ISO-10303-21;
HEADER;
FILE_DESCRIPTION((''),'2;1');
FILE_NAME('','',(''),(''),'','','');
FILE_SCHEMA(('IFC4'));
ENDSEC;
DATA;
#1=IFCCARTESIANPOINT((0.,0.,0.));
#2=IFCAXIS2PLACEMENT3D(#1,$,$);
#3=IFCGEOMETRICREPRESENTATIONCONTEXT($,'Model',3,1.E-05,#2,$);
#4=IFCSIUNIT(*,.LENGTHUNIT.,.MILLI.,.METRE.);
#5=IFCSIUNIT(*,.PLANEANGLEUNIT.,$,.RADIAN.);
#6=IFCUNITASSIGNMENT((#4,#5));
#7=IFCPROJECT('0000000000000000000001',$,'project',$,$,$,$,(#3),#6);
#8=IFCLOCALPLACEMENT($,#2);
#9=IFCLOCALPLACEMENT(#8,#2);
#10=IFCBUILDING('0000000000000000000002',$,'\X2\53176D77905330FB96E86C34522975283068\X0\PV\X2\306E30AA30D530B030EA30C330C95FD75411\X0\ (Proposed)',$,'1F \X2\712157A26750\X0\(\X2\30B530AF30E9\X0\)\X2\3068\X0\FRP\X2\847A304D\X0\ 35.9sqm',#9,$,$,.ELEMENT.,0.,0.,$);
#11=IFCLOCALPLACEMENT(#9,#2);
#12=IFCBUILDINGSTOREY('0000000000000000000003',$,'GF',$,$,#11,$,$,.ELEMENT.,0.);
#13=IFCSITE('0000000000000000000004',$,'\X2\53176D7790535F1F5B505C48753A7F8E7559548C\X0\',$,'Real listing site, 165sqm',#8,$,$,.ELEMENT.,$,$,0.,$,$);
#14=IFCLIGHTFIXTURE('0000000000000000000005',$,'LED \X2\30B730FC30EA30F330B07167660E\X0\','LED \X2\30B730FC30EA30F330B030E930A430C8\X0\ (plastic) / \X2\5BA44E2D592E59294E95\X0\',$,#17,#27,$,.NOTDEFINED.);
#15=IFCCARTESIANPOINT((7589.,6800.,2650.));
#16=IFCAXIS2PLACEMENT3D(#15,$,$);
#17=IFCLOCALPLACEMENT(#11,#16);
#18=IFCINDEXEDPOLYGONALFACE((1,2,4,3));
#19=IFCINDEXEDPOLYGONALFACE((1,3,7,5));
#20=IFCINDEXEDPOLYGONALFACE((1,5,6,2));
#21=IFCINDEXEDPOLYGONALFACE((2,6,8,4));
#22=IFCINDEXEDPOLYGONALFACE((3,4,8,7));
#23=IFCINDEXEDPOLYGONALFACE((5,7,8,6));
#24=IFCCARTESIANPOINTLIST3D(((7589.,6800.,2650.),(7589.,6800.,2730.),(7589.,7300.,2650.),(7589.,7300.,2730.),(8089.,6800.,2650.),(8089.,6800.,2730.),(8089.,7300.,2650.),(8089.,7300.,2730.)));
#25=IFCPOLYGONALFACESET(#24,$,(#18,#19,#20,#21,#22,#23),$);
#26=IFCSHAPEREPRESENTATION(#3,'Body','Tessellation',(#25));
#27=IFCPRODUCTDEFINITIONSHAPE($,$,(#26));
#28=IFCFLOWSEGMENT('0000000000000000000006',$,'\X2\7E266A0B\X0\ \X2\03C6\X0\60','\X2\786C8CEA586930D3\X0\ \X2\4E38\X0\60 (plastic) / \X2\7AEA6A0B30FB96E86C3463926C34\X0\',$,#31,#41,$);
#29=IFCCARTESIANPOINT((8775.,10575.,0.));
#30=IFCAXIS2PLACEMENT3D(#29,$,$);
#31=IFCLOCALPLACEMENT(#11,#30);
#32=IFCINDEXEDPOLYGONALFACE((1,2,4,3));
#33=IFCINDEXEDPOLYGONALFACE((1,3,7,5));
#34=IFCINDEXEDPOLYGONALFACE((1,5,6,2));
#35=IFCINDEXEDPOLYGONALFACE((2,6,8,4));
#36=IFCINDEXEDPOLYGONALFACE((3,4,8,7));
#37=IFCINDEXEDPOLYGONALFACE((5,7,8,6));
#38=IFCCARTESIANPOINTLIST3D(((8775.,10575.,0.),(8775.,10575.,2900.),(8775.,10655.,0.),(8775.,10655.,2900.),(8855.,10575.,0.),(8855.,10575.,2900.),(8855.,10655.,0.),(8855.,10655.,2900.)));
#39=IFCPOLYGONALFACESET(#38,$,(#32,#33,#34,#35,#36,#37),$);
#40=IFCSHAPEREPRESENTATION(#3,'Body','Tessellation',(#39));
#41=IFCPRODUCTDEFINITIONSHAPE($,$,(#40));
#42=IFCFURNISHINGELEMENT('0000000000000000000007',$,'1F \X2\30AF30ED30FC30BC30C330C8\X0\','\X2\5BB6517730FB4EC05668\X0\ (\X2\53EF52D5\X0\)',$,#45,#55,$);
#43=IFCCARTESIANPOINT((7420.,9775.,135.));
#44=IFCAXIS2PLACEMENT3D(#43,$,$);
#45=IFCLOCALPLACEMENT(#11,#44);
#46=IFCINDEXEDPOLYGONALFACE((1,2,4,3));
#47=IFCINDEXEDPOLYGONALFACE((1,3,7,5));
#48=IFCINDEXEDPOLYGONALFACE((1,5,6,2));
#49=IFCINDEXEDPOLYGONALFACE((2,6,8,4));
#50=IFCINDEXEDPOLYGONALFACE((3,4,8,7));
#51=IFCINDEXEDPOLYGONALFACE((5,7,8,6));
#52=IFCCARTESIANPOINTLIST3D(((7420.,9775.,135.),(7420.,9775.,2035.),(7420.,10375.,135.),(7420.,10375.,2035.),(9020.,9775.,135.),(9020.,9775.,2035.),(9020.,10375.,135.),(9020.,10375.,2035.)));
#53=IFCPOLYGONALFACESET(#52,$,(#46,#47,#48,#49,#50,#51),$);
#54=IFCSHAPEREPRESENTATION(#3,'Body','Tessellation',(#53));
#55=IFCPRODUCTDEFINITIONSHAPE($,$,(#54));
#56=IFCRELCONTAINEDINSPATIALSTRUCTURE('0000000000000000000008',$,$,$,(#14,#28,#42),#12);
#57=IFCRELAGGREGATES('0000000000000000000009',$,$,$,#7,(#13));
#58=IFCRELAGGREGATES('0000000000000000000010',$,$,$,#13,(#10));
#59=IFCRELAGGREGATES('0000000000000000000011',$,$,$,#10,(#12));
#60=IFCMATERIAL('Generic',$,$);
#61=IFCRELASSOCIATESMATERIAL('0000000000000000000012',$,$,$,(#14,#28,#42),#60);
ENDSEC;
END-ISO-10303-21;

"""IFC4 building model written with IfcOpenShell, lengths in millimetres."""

from ifc_helpers import new_model, si_unit, frame, frame_2d, origin, place, context, project, spatial, rectangle, extrude, material, element, save


model = new_model("IFC4")

# Units and contexts
model_context = context("Model", 3, precision=1e-05, world=origin())
ifc_project = project(units=[si_unit("LENGTHUNIT", "METRE", prefix="MILLI"), si_unit("PLANEANGLEUNIT", "RADIAN")], contexts=[model_context])

# Site, building, storey
site_placement = place(None, origin())
site = spatial("IfcSite", under=ifc_project, at=site_placement, Name="北海道弟子屈町美留和", ObjectType="Real listing site, 165sqm", CompositionType="ELEMENT", RefElevation=0.0)
building_placement = place(site_placement, origin())
building = spatial("IfcBuilding", under=site, at=building_placement, Name="北海道・雨水利用とPVのオフグリッド志向 (Proposed)", ObjectType="1F 無垢材(サクラ)とFRP葺き 35.9sqm", CompositionType="ELEMENT", ElevationOfRefHeight=0.0, ElevationOfTerrain=0.0)
storey_placement = place(building_placement, origin())
storey = spatial("IfcBuildingStorey", under=building, at=storey_placement, Name="GF", CompositionType="ELEMENT", Elevation=0.0)

# Shared definitions
ifc_material_1 = material(Name="Generic")

# Light fixture
light_fixture_placement = place(storey_placement, frame((7589.0, 6800.0, 2650.0)))
element("IfcLightFixture", 1, at=light_fixture_placement, inside=storey, material=ifc_material_1, Name="LED シーリング照明", Description="LED シーリングライト (plastic) / 室中央天井", PredefinedType="NOTDEFINED", context=model_context, shape_type="SweptSolid", body=[
    extrude(rectangle(XDim=500.0, YDim=500.0, at=frame_2d((250.0, 250.0))), frame((7589.0, 6800.0, 2650.0)), (0.0, 0.0, 1.0), 80.0),
])

# Flow segment
flow_segment_placement = place(storey_placement, frame((8775.0, 10575.0, 0.0)))
element("IfcFlowSegment", 2, at=flow_segment_placement, inside=storey, material=ifc_material_1, Name="縦樋 φ60", Description="硬質塩ビ 丸60 (plastic) / 竪樋・雨水排水", context=model_context, shape_type="SweptSolid", body=[
    extrude(rectangle(XDim=80.0, YDim=80.0, at=frame_2d((40.0, 40.0))), frame((8775.0, 10575.0, 0.0)), (0.0, 0.0, 1.0), 2900.0),
])

# Furnishing element
furnishing_placement = place(storey_placement, frame((7420.0, 9775.0, 135.0)))
element("IfcFurnishingElement", 3, at=furnishing_placement, inside=storey, material=ifc_material_1, Name="1F クローゼット", Description="家具・什器 (可動)", context=model_context, shape_type="SweptSolid", body=[
    extrude(rectangle(XDim=1600.0, YDim=600.0, at=frame_2d((800.0, 300.0))), frame((7420.0, 9775.0, 135.0)), (0.0, 0.0, 1.0), 1900.0),
])

save(model, "model.ifc")
